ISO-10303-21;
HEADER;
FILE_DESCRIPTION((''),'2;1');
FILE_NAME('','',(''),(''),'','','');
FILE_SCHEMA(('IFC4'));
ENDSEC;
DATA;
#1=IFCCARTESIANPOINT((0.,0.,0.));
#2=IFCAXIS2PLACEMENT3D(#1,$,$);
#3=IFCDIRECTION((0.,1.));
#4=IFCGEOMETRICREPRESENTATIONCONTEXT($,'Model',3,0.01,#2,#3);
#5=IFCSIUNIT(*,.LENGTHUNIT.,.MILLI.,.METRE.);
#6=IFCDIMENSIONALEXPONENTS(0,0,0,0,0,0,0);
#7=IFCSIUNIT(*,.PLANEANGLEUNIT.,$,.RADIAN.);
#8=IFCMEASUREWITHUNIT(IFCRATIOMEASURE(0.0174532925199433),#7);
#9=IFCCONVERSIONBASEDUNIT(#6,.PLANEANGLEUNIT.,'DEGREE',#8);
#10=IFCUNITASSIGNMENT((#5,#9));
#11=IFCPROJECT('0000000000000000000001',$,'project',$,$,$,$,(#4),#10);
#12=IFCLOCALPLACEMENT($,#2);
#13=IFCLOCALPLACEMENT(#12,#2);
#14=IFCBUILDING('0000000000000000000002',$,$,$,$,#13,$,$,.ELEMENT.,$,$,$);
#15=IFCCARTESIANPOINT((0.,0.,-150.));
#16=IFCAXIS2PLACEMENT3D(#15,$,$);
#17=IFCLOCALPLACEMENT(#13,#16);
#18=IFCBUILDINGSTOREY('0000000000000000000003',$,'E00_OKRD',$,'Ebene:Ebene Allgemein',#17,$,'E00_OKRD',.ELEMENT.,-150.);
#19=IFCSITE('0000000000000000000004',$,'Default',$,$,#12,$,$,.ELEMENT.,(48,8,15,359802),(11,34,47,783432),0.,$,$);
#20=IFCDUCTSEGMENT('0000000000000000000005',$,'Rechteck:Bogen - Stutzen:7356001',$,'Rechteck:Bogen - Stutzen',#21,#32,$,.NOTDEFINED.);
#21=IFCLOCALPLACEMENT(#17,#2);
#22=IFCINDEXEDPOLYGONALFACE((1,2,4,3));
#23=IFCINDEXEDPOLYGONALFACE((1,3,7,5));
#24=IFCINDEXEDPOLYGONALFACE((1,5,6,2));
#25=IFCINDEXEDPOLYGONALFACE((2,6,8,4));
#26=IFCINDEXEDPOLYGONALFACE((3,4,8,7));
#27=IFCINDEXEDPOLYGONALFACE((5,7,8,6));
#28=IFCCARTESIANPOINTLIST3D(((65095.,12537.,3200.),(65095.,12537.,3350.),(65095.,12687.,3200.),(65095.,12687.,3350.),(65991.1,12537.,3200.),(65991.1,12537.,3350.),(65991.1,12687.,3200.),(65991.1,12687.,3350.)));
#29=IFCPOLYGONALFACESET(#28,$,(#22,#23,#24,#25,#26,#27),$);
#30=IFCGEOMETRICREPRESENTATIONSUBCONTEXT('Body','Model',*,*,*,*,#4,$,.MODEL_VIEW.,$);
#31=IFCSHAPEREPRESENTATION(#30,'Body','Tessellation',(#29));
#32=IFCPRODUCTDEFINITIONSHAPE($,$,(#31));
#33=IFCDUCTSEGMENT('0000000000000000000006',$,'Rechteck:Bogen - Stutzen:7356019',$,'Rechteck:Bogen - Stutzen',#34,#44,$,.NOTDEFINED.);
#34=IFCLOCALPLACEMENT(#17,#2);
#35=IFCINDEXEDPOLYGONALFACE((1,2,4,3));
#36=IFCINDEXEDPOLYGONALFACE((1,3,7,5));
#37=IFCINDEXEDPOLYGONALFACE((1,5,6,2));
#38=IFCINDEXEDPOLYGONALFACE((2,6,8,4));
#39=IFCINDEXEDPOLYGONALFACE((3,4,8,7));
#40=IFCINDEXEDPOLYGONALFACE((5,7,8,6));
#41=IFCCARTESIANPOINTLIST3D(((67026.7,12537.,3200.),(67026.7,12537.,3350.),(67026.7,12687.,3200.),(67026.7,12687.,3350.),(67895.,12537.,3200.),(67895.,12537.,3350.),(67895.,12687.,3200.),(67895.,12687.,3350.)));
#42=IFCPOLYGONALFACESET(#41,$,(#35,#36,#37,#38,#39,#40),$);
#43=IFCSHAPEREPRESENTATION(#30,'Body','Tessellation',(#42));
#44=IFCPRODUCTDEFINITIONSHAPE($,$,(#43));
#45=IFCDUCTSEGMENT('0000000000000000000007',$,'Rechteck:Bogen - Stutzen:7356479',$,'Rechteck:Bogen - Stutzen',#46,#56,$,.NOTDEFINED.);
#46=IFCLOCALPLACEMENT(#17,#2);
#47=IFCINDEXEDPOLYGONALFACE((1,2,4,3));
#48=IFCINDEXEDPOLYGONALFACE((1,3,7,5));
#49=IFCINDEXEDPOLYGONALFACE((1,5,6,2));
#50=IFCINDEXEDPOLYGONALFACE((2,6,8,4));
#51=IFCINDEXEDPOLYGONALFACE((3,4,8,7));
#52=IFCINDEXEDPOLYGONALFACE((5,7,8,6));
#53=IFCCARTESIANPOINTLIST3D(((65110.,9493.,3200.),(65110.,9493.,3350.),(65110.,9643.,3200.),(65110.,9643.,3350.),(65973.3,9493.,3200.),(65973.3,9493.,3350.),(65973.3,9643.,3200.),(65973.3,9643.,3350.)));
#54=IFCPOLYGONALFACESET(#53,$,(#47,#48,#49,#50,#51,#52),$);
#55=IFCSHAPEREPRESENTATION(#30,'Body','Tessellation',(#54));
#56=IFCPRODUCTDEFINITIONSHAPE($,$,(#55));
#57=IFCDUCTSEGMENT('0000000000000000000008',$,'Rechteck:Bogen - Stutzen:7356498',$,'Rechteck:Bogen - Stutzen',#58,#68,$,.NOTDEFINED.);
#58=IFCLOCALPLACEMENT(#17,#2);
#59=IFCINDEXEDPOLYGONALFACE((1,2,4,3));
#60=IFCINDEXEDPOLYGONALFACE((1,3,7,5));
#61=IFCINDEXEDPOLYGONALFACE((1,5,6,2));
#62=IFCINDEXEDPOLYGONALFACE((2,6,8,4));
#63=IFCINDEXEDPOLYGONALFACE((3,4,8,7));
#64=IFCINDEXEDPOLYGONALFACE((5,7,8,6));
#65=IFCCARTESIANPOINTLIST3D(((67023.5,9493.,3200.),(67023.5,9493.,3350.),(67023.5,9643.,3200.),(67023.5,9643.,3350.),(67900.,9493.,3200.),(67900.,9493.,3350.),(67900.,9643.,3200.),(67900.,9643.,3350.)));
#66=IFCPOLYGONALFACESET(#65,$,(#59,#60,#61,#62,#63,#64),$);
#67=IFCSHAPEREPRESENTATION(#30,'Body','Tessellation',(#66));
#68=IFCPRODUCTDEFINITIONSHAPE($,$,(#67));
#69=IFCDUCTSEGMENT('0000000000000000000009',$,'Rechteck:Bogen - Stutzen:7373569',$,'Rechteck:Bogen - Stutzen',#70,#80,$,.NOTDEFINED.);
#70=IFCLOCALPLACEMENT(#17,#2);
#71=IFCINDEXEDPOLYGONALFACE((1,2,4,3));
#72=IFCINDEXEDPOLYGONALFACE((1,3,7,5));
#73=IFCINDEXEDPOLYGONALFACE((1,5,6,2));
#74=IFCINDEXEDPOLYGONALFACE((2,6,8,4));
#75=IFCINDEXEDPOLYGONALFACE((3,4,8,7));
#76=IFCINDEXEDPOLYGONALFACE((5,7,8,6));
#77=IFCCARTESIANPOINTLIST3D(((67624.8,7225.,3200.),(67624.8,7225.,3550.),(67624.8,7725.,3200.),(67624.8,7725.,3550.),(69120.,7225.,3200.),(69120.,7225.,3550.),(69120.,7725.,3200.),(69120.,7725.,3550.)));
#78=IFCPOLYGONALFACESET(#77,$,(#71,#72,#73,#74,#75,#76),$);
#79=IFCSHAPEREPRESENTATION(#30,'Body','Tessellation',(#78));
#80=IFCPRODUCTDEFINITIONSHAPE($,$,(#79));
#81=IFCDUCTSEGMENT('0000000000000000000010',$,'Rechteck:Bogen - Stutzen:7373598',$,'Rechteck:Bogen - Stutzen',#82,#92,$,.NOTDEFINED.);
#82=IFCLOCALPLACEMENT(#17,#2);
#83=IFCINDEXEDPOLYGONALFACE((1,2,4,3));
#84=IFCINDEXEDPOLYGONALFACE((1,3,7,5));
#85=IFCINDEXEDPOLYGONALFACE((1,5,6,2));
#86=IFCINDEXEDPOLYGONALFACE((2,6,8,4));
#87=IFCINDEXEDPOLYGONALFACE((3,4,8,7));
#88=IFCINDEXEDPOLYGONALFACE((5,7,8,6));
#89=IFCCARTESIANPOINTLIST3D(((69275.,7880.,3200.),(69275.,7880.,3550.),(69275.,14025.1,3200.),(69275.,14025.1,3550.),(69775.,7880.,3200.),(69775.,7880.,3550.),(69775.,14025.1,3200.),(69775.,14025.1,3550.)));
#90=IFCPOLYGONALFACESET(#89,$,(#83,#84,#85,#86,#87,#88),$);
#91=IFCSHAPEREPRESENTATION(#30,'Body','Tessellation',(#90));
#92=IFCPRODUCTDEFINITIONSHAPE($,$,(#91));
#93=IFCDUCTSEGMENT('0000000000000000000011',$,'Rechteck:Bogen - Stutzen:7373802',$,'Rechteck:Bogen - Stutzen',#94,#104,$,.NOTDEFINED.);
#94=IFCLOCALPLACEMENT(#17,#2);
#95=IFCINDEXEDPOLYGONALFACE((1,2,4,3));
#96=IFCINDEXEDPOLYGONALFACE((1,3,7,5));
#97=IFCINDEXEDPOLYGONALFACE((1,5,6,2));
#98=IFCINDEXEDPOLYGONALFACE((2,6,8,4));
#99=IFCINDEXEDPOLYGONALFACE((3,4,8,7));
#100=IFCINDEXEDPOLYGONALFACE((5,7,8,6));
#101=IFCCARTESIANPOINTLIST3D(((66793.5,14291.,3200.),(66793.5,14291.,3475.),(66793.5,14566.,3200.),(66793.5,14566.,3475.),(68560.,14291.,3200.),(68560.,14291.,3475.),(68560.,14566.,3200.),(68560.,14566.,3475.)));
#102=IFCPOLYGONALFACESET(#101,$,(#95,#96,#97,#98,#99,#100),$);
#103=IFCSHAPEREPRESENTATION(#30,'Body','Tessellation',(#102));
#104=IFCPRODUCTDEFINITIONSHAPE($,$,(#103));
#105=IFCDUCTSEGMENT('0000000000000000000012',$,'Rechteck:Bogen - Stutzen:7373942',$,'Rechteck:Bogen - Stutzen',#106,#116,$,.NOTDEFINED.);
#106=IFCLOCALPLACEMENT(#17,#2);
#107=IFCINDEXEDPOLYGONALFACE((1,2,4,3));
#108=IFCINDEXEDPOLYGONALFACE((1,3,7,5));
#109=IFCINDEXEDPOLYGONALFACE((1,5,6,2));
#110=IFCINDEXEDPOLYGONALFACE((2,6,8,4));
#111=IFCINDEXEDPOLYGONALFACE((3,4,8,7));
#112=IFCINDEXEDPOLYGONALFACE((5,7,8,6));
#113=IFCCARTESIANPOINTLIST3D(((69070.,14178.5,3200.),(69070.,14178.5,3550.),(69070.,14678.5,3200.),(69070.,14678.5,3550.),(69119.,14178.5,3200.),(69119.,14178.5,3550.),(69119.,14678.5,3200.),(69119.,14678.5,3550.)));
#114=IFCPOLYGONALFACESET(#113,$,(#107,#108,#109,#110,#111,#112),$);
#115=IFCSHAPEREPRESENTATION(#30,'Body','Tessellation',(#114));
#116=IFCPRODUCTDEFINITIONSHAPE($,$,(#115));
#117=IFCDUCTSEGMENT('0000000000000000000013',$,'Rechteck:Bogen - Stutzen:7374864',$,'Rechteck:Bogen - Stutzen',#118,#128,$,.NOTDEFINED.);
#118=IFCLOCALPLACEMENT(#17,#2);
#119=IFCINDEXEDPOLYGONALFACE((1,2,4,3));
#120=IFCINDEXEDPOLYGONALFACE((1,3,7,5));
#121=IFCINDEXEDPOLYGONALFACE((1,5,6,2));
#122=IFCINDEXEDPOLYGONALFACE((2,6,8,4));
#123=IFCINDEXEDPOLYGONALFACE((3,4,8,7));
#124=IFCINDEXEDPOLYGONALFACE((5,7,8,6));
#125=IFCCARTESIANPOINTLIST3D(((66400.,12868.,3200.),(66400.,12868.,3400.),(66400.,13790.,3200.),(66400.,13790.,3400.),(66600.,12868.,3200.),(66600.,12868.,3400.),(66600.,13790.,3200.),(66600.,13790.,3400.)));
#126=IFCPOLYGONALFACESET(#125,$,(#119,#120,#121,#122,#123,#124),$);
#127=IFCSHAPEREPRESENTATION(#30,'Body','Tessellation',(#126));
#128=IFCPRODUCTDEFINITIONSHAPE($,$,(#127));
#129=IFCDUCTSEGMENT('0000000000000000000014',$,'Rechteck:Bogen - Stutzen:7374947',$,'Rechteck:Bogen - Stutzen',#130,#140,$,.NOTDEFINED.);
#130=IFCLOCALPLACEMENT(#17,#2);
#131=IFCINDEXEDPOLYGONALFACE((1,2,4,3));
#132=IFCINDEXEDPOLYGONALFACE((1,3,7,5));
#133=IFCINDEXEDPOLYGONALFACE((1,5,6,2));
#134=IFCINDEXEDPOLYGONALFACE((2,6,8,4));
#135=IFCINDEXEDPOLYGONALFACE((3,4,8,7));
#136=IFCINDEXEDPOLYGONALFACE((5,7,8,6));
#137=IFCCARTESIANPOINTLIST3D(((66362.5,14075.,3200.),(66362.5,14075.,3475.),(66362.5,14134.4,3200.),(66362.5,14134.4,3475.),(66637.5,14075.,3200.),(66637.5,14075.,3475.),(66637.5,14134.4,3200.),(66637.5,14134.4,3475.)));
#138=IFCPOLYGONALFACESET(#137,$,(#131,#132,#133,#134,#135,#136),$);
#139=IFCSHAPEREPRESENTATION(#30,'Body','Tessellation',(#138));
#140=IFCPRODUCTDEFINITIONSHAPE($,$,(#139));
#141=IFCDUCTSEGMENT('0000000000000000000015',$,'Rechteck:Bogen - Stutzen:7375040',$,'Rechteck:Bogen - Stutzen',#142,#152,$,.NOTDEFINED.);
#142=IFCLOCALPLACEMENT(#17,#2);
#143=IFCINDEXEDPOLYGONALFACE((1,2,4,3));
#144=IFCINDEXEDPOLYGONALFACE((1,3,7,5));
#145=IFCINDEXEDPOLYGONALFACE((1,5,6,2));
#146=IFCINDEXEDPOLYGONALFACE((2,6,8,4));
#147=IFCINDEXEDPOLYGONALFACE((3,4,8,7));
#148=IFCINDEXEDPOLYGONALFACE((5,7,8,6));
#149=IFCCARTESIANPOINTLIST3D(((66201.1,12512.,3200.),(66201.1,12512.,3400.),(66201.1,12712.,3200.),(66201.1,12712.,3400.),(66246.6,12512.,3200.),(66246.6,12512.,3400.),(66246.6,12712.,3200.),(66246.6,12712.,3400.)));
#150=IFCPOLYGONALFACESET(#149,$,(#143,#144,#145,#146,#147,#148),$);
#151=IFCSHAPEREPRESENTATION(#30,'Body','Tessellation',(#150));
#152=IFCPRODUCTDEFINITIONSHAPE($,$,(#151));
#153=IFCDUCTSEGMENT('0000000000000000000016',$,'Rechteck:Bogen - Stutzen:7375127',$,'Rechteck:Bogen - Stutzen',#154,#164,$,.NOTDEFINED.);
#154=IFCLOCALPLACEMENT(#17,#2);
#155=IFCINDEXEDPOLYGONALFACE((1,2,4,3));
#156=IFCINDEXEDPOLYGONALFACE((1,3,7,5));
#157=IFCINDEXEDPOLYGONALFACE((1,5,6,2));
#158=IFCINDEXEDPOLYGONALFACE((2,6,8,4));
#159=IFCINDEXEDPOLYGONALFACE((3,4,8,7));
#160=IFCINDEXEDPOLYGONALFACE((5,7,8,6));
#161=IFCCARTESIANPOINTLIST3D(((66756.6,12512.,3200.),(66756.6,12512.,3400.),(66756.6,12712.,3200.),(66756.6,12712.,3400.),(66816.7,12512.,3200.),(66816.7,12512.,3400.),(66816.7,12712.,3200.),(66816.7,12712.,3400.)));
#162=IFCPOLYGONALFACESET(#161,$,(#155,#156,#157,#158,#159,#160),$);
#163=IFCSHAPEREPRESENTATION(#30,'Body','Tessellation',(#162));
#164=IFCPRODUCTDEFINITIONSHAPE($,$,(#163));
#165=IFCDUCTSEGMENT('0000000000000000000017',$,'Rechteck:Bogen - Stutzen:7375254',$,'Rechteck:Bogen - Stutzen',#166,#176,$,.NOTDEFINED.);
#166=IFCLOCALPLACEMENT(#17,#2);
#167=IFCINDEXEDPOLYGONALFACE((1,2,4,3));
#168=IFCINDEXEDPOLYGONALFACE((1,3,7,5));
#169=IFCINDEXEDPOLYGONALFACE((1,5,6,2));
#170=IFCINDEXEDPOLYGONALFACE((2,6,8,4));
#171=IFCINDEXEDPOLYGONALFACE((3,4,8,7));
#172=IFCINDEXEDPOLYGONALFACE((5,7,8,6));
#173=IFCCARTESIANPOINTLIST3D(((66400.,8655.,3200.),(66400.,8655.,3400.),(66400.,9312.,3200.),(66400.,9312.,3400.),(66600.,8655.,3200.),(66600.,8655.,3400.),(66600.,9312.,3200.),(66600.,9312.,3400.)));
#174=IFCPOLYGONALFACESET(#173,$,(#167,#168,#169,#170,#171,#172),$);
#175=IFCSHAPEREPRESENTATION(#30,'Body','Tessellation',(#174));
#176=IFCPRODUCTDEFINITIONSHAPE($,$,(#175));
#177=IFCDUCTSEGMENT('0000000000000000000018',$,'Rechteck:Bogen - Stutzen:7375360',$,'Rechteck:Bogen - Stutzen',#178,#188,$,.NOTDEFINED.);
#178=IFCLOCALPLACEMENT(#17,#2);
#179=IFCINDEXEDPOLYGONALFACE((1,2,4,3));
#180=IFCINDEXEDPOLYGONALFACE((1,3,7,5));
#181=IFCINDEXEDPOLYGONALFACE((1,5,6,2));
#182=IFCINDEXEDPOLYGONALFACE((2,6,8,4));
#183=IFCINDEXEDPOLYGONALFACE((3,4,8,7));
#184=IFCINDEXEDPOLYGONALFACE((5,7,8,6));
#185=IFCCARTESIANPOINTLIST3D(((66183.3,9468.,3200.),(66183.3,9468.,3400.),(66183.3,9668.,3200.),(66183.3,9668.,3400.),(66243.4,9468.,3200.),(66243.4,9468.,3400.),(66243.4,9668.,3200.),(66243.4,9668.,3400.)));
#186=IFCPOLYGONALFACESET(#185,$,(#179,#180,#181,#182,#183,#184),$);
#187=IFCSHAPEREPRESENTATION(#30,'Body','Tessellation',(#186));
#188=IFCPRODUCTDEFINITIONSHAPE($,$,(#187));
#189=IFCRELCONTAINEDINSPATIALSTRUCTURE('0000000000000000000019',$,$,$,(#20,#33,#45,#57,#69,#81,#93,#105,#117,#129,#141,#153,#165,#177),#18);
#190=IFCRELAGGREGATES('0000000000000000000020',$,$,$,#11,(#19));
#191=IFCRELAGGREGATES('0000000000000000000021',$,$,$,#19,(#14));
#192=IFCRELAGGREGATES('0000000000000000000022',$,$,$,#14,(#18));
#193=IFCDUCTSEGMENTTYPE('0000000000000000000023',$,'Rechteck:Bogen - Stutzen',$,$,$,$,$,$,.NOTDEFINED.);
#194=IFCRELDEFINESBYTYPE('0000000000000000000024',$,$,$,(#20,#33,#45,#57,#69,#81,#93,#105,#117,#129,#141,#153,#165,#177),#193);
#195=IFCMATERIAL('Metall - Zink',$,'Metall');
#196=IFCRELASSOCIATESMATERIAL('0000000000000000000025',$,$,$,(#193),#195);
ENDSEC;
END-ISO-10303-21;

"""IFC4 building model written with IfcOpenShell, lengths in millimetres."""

from ifc_helpers import new_model, entity, si_unit, converted_unit, direction, frame, frame_2d, origin, origin_2d_with_axis, place, context, subcontext, project, spatial, rectangle, extrude, material, type_object, element, save


model = new_model("IFC4")

# Units and contexts
model_context = context("Model", 3, precision=0.01, world=origin(), true_north=direction((0.0, 1.0)))
body_context = subcontext(model_context, "Body", "Model", "MODEL_VIEW")
ifc_project = project(units=[si_unit("LENGTHUNIT", "METRE", prefix="MILLI"), converted_unit("PLANEANGLEUNIT", "DEGREE", entity("IfcRatioMeasure", 0.0174532925199433), si_unit("PLANEANGLEUNIT", "RADIAN"), dimensions=[0, 0, 0, 0, 0, 0, 0])], contexts=[model_context])

# Site, building, storey
site_placement = place(None, origin())
site = spatial("IfcSite", under=ifc_project, at=site_placement, Name="Default", CompositionType="ELEMENT", RefLatitude=(48, 8, 15, 359802), RefLongitude=(11, 34, 47, 783432), RefElevation=0.0)
building_placement = place(site_placement, origin())
building = spatial("IfcBuilding", under=site, at=building_placement, CompositionType="ELEMENT")
storey_placement = place(building_placement, frame((0.0, 0.0, -150.0)))
storey = spatial("IfcBuildingStorey", under=building, at=storey_placement, Name="E00_OKRD", ObjectType="Ebene:Ebene Allgemein", LongName="E00_OKRD", CompositionType="ELEMENT", Elevation=-150.0)

# Duct segments
ifc_material_1 = material(Name="Metall - Zink", Category="Metall")
duct_segment_type_1 = type_object("IfcDuctSegmentType", Name="Rechteck:Bogen - Stutzen", PredefinedType="NOTDEFINED", material=ifc_material_1)
duct_segment_1_placement = place(storey_placement, frame((65095.0, 12537.0, 3200.0)))
element("IfcDuctSegment", 1, at=duct_segment_1_placement, inside=storey, type_object=duct_segment_type_1, Name="Rechteck:Bogen - Stutzen:7356001", ObjectType="Rechteck:Bogen - Stutzen", PredefinedType="NOTDEFINED", context=body_context, shape_type="SweptSolid", body=[
    extrude(rectangle(XDim=896.2, YDim=150.0, at=frame_2d((0.0, 0.0), x_axis=(1.0, 0.0))), frame((448.1, 75.0, 0.0)), (0.0, 0.0, 1.0), 150.0),
])
duct_segment_2_placement = place(storey_placement, frame((67026.7, 12537.0, 3200.0)))
element("IfcDuctSegment", 2, at=duct_segment_2_placement, inside=storey, type_object=duct_segment_type_1, Name="Rechteck:Bogen - Stutzen:7356019", ObjectType="Rechteck:Bogen - Stutzen", PredefinedType="NOTDEFINED", context=body_context, shape_type="SweptSolid", body=[
    extrude(rectangle(XDim=868.3, YDim=150.0, at=origin_2d_with_axis()), frame((434.2, 75.0, 0.0), z_axis=(0.0, 0.0, 1.0), x_axis=(-1.0, 0.0, 0.0)), (0.0, 0.0, 1.0), 150.0),
])
duct_segment_3_placement = place(storey_placement, frame((65110.0, 9493.0, 3200.0)))
element("IfcDuctSegment", 3, at=duct_segment_3_placement, inside=storey, type_object=duct_segment_type_1, Name="Rechteck:Bogen - Stutzen:7356479", ObjectType="Rechteck:Bogen - Stutzen", PredefinedType="NOTDEFINED", context=body_context, shape_type="SweptSolid", body=[
    extrude(rectangle(XDim=863.3, YDim=150.0, at=frame_2d((0.0, 0.0), x_axis=(1.0, 0.0))), frame((431.7, 75.0, 0.0)), (0.0, 0.0, 1.0), 150.0),
])
duct_segment_4_placement = place(storey_placement, frame((67023.5, 9493.0, 3200.0)))
element("IfcDuctSegment", 4, at=duct_segment_4_placement, inside=storey, type_object=duct_segment_type_1, Name="Rechteck:Bogen - Stutzen:7356498", ObjectType="Rechteck:Bogen - Stutzen", PredefinedType="NOTDEFINED", context=body_context, shape_type="SweptSolid", body=[
    extrude(rectangle(XDim=876.5, YDim=150.0, at=frame_2d((0.0, 0.0), x_axis=(1.0, 0.0))), frame((438.3, 75.0, 0.0), z_axis=(0.0, 0.0, 1.0), x_axis=(-1.0, 0.0, 0.0)), (0.0, 0.0, 1.0), 150.0),
])
duct_segment_5_placement = place(storey_placement, frame((67624.8, 7225.0, 3200.0)))
element("IfcDuctSegment", 5, at=duct_segment_5_placement, inside=storey, type_object=duct_segment_type_1, Name="Rechteck:Bogen - Stutzen:7373569", ObjectType="Rechteck:Bogen - Stutzen", PredefinedType="NOTDEFINED", context=body_context, shape_type="SweptSolid", body=[
    extrude(rectangle(XDim=1495.1, YDim=500.0, at=frame_2d((0.0, 0.0), x_axis=(1.0, 0.0))), frame((747.6, 250.0, 0.0), z_axis=(0.0, 0.0, 1.0), x_axis=(-1.0, 0.0, 0.0)), (0.0, 0.0, 1.0), 350.0),
])
duct_segment_6_placement = place(storey_placement, frame((69275.0, 7880.0, 3200.0)))
element("IfcDuctSegment", 6, at=duct_segment_6_placement, inside=storey, type_object=duct_segment_type_1, Name="Rechteck:Bogen - Stutzen:7373598", ObjectType="Rechteck:Bogen - Stutzen", PredefinedType="NOTDEFINED", context=body_context, shape_type="SweptSolid", body=[
    extrude(rectangle(XDim=6145.1, YDim=500.0, at=frame_2d((0.0, 0.0), x_axis=(1.0, 0.0))), frame((250.0, 3072.6, 0.0), z_axis=(0.0, 0.0, 1.0), x_axis=(0.0, 1.0, 0.0)), (0.0, 0.0, 1.0), 350.0),
])
duct_segment_7_placement = place(storey_placement, frame((66793.5, 14291.0, 3200.0)))
element("IfcDuctSegment", 7, at=duct_segment_7_placement, inside=storey, type_object=duct_segment_type_1, Name="Rechteck:Bogen - Stutzen:7373802", ObjectType="Rechteck:Bogen - Stutzen", PredefinedType="NOTDEFINED", context=body_context, shape_type="SweptSolid", body=[
    extrude(rectangle(XDim=1766.5, YDim=275.0, at=frame_2d((0.0, 0.0), x_axis=(1.0, 0.0))), frame((883.2, 137.5, 0.0)), (0.0, 0.0, 1.0), 275.0),
])
duct_segment_8_placement = place(storey_placement, frame((69070.0, 14178.5, 3200.0)))
element("IfcDuctSegment", 8, at=duct_segment_8_placement, inside=storey, type_object=duct_segment_type_1, Name="Rechteck:Bogen - Stutzen:7373942", ObjectType="Rechteck:Bogen - Stutzen", PredefinedType="NOTDEFINED", context=body_context, shape_type="SweptSolid", body=[
    extrude(rectangle(XDim=49.0, YDim=500.0, at=frame_2d((0.0, 0.0), x_axis=(1.0, 0.0))), frame((24.5, 250.0, 0.0)), (0.0, 0.0, 1.0), 350.0),
])
duct_segment_9_placement = place(storey_placement, frame((66400.0, 12868.0, 3200.0)))
element("IfcDuctSegment", 9, at=duct_segment_9_placement, inside=storey, type_object=duct_segment_type_1, Name="Rechteck:Bogen - Stutzen:7374864", ObjectType="Rechteck:Bogen - Stutzen", PredefinedType="NOTDEFINED", context=body_context, shape_type="SweptSolid", body=[
    extrude(rectangle(XDim=922.0, YDim=200.0, at=frame_2d((0.0, 0.0), x_axis=(1.0, 0.0))), frame((100.0, 461.0, 0.0), z_axis=(0.0, 0.0, 1.0), x_axis=(0.0, 1.0, 0.0)), (0.0, 0.0, 1.0), 200.0),
])
duct_segment_10_placement = place(storey_placement, frame((66362.5, 14075.0, 3200.0)))
element("IfcDuctSegment", 10, at=duct_segment_10_placement, inside=storey, type_object=duct_segment_type_1, Name="Rechteck:Bogen - Stutzen:7374947", ObjectType="Rechteck:Bogen - Stutzen", PredefinedType="NOTDEFINED", context=body_context, shape_type="SweptSolid", body=[
    extrude(rectangle(XDim=59.4, YDim=275.0, at=frame_2d((0.0, 0.0), x_axis=(1.0, 0.0))), frame((137.5, 29.7, 0.0), z_axis=(0.0, 0.0, 1.0), x_axis=(0.0, -1.0, 0.0)), (0.0, 0.0, 1.0), 275.0),
])
duct_segment_11_placement = place(storey_placement, frame((66201.1, 12512.0, 3200.0)))
element("IfcDuctSegment", 11, at=duct_segment_11_placement, inside=storey, type_object=duct_segment_type_1, Name="Rechteck:Bogen - Stutzen:7375040", ObjectType="Rechteck:Bogen - Stutzen", PredefinedType="NOTDEFINED", context=body_context, shape_type="SweptSolid", body=[
    extrude(rectangle(XDim=45.4, YDim=200.0, at=frame_2d((0.0, 0.0), x_axis=(1.0, 0.0))), frame((22.7, 100.0, 0.0), z_axis=(0.0, 0.0, 1.0), x_axis=(-1.0, 0.0, 0.0)), (0.0, 0.0, 1.0), 200.0),
])
duct_segment_12_placement = place(storey_placement, frame((66756.6, 12512.0, 3200.0)))
element("IfcDuctSegment", 12, at=duct_segment_12_placement, inside=storey, type_object=duct_segment_type_1, Name="Rechteck:Bogen - Stutzen:7375127", ObjectType="Rechteck:Bogen - Stutzen", PredefinedType="NOTDEFINED", context=body_context, shape_type="SweptSolid", body=[
    extrude(rectangle(XDim=60.1, YDim=200.0, at=frame_2d((0.0, 0.0), x_axis=(1.0, 0.0))), frame((30.0, 100.0, 0.0)), (0.0, 0.0, 1.0), 200.0),
])
duct_segment_13_placement = place(storey_placement, frame((66400.0, 8655.0, 3200.0)))
element("IfcDuctSegment", 13, at=duct_segment_13_placement, inside=storey, type_object=duct_segment_type_1, Name="Rechteck:Bogen - Stutzen:7375254", ObjectType="Rechteck:Bogen - Stutzen", PredefinedType="NOTDEFINED", context=body_context, shape_type="SweptSolid", body=[
    extrude(rectangle(XDim=657.0, YDim=200.0, at=origin_2d_with_axis()), frame((100.0, 328.5, 0.0), z_axis=(0.0, 0.0, 1.0), x_axis=(0.0, -1.0, 0.0)), (0.0, 0.0, 1.0), 200.0),
])
duct_segment_14_placement = place(storey_placement, frame((66183.3, 9468.0, 3200.0)))
element("IfcDuctSegment", 14, at=duct_segment_14_placement, inside=storey, type_object=duct_segment_type_1, Name="Rechteck:Bogen - Stutzen:7375360", ObjectType="Rechteck:Bogen - Stutzen", PredefinedType="NOTDEFINED", context=body_context, shape_type="SweptSolid", body=[
    extrude(rectangle(XDim=60.1, YDim=200.0, at=frame_2d((0.0, 0.0), x_axis=(1.0, 0.0))), frame((30.0, 100.0, 0.0), z_axis=(0.0, 0.0, 1.0), x_axis=(-1.0, 0.0, 0.0)), (0.0, 0.0, 1.0), 200.0),
])

save(model, "model.ifc")
